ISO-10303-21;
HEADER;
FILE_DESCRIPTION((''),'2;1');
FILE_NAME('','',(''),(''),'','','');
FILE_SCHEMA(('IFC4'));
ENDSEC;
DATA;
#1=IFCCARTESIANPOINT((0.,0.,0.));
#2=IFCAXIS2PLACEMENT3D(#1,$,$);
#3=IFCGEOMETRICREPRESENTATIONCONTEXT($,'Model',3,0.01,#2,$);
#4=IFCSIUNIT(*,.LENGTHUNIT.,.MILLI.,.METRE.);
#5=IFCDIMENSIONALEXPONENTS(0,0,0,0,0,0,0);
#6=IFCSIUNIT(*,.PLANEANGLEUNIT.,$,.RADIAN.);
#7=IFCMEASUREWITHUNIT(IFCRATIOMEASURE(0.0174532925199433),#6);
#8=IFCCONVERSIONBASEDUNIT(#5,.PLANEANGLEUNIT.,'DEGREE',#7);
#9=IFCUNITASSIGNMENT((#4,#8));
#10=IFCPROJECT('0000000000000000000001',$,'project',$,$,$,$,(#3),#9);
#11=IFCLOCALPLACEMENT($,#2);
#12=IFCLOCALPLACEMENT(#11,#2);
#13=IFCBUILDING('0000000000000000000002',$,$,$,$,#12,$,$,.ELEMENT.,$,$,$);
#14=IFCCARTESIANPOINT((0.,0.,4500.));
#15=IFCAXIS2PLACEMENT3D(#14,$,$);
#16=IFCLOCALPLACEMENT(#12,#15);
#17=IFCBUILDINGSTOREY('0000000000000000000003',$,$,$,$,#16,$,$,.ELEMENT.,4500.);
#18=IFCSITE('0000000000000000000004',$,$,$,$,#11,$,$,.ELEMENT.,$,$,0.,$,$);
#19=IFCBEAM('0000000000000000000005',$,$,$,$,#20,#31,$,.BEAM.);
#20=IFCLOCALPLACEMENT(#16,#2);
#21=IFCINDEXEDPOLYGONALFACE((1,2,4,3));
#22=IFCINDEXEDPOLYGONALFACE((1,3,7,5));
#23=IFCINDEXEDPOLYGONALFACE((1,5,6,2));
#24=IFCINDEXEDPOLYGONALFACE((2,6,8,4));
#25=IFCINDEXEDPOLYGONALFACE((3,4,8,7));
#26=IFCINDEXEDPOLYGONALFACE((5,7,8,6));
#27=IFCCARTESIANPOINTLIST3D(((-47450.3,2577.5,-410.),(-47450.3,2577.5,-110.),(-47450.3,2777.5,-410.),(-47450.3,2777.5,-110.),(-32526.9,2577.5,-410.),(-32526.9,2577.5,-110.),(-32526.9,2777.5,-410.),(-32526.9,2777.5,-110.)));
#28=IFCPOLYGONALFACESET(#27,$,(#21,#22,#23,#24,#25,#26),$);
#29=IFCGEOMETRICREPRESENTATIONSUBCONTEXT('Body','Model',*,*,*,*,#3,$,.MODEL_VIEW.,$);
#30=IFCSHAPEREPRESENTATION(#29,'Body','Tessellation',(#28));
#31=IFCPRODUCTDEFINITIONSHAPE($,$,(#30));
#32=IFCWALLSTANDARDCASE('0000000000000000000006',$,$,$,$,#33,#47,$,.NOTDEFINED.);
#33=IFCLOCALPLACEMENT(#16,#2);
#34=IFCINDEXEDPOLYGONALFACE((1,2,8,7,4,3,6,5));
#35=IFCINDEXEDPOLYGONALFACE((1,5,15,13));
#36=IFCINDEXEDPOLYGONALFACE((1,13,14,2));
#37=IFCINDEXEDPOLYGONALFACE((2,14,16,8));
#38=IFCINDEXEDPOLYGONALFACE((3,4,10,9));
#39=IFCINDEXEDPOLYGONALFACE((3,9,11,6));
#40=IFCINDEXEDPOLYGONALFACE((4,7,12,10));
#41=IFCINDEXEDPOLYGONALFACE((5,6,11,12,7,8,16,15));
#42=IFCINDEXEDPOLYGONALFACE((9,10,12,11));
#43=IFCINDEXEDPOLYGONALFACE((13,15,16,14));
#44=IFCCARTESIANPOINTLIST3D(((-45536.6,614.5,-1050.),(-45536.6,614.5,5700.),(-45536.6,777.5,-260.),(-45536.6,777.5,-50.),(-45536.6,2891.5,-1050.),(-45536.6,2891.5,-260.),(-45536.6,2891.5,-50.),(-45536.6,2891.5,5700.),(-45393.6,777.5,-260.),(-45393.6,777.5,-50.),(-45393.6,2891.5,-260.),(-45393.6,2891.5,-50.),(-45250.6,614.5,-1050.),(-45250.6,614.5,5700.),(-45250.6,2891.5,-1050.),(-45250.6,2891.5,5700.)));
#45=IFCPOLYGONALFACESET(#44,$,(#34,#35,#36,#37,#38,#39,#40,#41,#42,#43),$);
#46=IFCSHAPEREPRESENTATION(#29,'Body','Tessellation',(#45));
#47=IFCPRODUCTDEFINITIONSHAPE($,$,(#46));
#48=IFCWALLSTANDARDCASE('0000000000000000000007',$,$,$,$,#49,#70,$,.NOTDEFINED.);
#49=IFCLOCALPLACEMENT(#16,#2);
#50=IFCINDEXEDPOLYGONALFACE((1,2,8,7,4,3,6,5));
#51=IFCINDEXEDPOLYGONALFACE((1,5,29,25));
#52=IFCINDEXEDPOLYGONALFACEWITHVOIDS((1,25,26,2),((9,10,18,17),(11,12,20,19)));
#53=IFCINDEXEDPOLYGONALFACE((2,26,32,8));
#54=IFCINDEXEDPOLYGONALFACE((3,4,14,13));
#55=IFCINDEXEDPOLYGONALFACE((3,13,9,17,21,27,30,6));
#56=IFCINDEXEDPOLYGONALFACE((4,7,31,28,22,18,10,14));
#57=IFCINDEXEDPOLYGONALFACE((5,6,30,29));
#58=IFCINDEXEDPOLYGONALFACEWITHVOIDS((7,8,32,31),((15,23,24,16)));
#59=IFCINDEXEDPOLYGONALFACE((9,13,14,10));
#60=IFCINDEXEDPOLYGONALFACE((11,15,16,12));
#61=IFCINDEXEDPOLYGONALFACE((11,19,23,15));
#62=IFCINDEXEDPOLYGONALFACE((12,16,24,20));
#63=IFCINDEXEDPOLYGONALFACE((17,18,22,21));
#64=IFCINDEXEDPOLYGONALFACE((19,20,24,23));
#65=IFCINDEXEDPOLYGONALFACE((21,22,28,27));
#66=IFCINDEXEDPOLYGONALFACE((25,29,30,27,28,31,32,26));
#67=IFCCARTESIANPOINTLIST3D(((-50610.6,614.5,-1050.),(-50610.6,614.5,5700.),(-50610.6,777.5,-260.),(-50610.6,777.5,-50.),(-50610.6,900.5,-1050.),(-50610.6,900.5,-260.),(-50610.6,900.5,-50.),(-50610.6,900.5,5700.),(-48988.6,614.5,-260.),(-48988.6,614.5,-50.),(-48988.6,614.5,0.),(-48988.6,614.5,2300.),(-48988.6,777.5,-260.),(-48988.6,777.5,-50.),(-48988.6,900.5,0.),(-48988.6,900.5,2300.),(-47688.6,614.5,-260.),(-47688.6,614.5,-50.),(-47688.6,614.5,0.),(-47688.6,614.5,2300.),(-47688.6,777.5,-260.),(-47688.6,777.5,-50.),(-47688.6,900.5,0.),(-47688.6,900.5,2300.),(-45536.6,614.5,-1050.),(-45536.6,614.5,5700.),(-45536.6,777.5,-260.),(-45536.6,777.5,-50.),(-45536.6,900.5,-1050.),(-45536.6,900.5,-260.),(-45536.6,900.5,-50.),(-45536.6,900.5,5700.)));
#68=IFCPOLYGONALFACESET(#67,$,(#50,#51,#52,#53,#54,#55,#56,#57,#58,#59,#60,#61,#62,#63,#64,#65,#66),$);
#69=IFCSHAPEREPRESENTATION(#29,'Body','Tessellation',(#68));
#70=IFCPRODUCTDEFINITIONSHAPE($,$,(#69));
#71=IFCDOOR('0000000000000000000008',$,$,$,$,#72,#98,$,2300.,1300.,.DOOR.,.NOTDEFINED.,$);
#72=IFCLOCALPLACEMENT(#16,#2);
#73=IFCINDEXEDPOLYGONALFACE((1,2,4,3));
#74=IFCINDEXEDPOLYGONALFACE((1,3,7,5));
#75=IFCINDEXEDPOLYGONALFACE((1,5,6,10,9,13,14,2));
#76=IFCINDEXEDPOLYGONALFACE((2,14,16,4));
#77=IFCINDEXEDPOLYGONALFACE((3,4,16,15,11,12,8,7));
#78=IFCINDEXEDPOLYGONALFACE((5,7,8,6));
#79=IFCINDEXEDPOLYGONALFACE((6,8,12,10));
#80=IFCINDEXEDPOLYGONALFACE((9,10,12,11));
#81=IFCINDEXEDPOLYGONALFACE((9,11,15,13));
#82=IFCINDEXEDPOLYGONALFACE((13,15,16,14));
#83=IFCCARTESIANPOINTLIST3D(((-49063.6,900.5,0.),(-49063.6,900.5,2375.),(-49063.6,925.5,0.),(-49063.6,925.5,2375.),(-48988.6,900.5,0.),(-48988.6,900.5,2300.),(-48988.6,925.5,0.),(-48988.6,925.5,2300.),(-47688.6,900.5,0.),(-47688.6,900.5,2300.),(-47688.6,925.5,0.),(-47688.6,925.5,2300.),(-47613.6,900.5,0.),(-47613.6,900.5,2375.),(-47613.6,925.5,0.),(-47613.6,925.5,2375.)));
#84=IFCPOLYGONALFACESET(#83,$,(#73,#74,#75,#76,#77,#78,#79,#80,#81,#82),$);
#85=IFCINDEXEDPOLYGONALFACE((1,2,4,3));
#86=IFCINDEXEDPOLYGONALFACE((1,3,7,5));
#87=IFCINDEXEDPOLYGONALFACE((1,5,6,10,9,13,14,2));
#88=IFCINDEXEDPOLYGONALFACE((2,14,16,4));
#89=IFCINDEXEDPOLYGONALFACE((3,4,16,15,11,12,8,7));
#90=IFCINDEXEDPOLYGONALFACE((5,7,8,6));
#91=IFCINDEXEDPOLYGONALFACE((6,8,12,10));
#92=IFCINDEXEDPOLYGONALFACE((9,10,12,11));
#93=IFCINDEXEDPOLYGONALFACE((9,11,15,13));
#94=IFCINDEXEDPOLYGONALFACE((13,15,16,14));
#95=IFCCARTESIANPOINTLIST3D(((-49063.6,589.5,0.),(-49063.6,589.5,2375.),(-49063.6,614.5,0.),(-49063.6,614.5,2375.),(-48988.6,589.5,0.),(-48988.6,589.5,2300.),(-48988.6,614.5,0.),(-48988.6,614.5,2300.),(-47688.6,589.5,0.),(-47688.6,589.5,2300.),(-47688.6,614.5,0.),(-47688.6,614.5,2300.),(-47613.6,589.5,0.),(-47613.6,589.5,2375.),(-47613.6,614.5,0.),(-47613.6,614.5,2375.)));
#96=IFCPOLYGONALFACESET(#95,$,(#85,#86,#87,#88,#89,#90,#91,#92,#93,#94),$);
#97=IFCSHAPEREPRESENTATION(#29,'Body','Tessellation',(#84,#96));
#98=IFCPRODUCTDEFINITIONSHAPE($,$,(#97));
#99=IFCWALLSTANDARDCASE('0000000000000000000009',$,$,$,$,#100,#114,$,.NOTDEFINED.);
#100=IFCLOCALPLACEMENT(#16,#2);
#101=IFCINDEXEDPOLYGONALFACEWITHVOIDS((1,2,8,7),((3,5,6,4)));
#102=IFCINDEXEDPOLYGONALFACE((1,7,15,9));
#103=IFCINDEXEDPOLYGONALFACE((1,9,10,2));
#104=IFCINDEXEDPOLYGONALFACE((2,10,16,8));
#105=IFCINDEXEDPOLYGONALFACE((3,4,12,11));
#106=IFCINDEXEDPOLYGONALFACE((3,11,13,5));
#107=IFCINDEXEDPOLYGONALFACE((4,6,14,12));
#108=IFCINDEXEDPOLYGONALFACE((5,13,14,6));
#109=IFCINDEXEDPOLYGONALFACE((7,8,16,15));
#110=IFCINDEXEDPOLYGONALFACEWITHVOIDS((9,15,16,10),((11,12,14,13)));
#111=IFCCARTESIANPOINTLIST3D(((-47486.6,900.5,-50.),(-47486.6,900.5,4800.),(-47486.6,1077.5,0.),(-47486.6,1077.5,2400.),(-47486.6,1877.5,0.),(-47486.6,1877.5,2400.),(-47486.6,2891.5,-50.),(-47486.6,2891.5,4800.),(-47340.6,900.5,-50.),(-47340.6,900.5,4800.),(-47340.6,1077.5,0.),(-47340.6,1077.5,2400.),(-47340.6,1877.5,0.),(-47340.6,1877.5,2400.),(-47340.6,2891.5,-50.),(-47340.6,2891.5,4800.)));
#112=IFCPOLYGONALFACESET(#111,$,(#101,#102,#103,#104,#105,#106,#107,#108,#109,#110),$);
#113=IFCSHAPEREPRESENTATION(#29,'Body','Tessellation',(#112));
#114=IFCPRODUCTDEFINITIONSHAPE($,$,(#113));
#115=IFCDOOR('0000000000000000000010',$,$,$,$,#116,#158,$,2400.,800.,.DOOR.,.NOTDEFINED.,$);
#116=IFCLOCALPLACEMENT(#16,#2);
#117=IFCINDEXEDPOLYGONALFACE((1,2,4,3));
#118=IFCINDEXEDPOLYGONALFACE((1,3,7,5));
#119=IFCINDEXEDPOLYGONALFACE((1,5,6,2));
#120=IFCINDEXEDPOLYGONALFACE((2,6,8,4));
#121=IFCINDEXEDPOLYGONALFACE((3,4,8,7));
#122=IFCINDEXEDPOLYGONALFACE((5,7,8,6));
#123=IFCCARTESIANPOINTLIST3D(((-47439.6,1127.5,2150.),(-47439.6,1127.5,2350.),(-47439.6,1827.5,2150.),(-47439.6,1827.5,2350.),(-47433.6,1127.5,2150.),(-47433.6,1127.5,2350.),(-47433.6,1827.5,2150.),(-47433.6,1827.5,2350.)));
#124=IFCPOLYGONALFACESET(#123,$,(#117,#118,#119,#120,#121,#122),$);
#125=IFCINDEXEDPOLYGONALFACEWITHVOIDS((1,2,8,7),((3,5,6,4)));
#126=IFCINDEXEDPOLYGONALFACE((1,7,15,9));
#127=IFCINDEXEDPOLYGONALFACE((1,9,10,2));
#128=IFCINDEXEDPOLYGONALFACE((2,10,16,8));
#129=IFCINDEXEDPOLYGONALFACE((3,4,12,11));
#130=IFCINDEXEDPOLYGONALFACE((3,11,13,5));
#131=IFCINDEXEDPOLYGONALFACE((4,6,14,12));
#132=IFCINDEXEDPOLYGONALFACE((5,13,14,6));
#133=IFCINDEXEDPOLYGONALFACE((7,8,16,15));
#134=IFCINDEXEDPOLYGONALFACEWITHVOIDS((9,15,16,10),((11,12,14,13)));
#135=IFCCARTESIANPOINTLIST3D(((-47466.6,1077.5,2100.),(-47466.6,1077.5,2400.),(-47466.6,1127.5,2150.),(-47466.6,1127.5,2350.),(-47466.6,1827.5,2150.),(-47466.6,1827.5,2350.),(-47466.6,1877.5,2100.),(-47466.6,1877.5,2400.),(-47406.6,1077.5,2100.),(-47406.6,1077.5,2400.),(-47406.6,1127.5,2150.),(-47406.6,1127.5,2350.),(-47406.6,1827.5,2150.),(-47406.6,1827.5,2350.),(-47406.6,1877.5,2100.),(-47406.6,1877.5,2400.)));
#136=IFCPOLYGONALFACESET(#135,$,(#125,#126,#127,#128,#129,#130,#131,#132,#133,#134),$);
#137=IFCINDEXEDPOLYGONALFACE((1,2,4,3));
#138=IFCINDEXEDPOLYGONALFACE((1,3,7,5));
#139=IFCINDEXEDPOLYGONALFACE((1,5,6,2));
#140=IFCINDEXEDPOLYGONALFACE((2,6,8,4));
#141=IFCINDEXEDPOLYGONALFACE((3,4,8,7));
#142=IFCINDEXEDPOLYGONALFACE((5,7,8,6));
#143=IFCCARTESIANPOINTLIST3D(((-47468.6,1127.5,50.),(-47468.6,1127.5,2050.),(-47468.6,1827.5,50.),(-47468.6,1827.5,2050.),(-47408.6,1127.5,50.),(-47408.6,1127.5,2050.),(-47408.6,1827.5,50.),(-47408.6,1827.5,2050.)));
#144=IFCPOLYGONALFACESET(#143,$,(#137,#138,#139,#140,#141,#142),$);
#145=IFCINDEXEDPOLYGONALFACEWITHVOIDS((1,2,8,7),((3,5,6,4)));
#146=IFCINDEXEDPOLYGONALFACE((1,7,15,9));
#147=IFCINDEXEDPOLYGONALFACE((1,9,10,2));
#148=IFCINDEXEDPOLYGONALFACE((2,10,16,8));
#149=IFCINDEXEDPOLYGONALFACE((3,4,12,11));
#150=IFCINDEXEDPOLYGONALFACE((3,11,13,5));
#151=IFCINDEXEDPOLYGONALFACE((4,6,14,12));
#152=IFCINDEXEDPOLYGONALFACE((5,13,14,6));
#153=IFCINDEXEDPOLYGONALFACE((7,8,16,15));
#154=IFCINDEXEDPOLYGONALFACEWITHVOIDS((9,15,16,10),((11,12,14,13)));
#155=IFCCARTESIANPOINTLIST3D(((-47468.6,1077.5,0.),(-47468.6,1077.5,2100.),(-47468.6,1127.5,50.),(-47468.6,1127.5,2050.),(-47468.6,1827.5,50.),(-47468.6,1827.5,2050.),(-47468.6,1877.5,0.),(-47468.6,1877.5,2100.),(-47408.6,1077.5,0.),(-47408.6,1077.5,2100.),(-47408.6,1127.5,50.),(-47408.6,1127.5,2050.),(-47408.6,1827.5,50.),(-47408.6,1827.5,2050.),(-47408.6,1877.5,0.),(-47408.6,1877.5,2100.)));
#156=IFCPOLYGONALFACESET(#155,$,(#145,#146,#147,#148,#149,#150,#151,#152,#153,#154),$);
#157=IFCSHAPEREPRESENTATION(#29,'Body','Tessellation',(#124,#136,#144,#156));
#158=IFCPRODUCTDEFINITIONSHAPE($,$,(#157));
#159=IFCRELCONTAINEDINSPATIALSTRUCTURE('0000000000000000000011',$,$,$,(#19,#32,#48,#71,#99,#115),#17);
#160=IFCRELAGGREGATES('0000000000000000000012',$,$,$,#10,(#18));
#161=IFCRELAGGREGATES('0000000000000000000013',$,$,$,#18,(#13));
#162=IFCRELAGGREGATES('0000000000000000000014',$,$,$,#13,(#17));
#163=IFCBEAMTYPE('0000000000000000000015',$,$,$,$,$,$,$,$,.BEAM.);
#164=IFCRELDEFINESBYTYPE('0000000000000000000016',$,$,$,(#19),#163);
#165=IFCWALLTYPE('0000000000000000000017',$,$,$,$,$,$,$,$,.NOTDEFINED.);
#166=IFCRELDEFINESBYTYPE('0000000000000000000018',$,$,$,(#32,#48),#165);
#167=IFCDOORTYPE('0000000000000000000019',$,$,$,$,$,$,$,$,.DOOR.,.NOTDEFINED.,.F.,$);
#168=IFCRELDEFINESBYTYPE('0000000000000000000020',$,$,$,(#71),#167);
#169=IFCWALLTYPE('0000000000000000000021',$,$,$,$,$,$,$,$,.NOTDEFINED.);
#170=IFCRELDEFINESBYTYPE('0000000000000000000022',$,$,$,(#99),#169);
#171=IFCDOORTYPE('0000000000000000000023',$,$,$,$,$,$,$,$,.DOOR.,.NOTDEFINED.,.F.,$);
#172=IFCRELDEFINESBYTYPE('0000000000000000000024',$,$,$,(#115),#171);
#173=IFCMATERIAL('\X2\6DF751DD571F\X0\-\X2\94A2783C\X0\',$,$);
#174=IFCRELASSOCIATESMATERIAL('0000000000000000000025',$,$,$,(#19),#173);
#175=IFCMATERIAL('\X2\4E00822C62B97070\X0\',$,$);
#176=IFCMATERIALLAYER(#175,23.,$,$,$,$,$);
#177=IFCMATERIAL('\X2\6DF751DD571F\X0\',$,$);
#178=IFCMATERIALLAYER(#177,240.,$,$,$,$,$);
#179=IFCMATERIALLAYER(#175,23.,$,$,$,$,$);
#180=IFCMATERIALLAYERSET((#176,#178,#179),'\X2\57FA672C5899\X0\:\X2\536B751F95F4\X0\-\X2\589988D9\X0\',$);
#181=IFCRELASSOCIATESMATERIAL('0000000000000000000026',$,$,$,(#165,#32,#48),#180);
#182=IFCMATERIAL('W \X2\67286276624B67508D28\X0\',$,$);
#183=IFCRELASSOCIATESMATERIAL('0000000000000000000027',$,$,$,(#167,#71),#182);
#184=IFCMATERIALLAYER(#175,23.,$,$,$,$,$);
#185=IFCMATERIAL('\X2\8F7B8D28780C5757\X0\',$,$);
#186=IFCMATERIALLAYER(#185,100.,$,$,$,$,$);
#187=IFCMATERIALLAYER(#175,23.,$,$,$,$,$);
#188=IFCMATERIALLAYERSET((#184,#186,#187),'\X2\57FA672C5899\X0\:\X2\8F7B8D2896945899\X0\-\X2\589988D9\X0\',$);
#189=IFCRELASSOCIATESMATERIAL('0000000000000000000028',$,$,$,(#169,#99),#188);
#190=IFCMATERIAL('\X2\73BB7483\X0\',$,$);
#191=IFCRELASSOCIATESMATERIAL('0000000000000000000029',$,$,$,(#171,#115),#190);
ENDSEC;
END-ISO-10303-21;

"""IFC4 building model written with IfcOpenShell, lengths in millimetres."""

from ifc_helpers import new_model, entity, si_unit, converted_unit, frame, frame_2d, origin, place, context, subcontext, project, spatial, polyline, rectangle, outline, extrude, source, transform, mapped, material, layer, layer_set, layer_usage, type_object, type_shapes, element, fill, save


model = new_model("IFC4")

# Units and contexts
model_context = context("Model", 3, precision=0.01, world=origin())
body_context = subcontext(model_context, "Body", "Model", "MODEL_VIEW")
ifc_project = project(units=[si_unit("LENGTHUNIT", "METRE", prefix="MILLI"), converted_unit("PLANEANGLEUNIT", "DEGREE", entity("IfcRatioMeasure", 0.0174532925199433), si_unit("PLANEANGLEUNIT", "RADIAN"), dimensions=[0, 0, 0, 0, 0, 0, 0])], contexts=[model_context])

# Site, building, storey
site_placement = place(None, origin())
site = spatial("IfcSite", under=ifc_project, at=site_placement, CompositionType="ELEMENT", RefElevation=0.0)
building_placement = place(site_placement, origin())
building = spatial("IfcBuilding", under=site, at=building_placement, CompositionType="ELEMENT")
storey_placement = place(building_placement, frame((0.0, 0.0, 4500.0)))
storey = spatial("IfcBuildingStorey", under=building, at=storey_placement, CompositionType="ELEMENT", Elevation=4500.0)

# Beam
ifc_material_1 = material(Name="混凝土-钢砼")
beam_type = type_object("IfcBeamType", PredefinedType="BEAM")
beam_placement = place(storey_placement, frame((-47413.6, 2677.5, -110.0)))
element("IfcBeam", 1, at=beam_placement, inside=storey, type_object=beam_type, material=ifc_material_1, PredefinedType="BEAM", context=body_context, shape_type="SweptSolid", body=[
    extrude(rectangle(XDim=300.0, YDim=200.0, at=frame_2d((0.0, 0.0), x_axis=(1.0, 0.0))), frame((-36.7, 0.0, -150.0), z_axis=(1.0, 0.0, 0.0), x_axis=(0.0, 0.0, -1.0)), (0.0, 0.0, 1.0), 14923.4),
])

# Wall, opening
ifc_material_2 = material(Name="一般抹灰")
ifc_layer_1 = layer(ifc_material_2, 23.0)
ifc_material_3 = material(Name="混凝土")
ifc_layer_2 = layer(ifc_material_3, 240.0)
ifc_layer_3 = layer(ifc_material_2, 23.0)
ifc_layer_set_1 = layer_set([ifc_layer_1, ifc_layer_2, ifc_layer_3], Name="基本墙:卫生间-墙裙")
ifc_layer_usage_1 = layer_usage(ifc_layer_set_1, "AXIS2", "NEGATIVE", 143.0)
wall_type_1 = type_object("IfcWallType", PredefinedType="NOTDEFINED", material=ifc_layer_set_1)
wall_1_placement = place(storey_placement, frame((-45393.6, 2891.5, -1050.0), z_axis=(0.0, 0.0, 1.0), x_axis=(0.0, -1.0, 0.0)))
wall_1 = element("IfcWallStandardCase", 2, at=wall_1_placement, inside=storey, type_object=wall_type_1, material=ifc_layer_usage_1, PredefinedType="NOTDEFINED", context=body_context, shape_type="SweptSolid", body=[
    extrude(rectangle(XDim=2277.0, YDim=286.0, at=frame_2d((1138.5, 0.0), x_axis=(-1.0, 0.0))), origin(), (0.0, 0.0, 1.0), 6750.0),
])
opening_1_placement = place(storey_placement, frame((-45393.6, 2891.5, -1050.0), z_axis=(0.0, 0.0, 1.0), x_axis=(0.0, -1.0, 0.0)))
element("IfcOpeningElement", 3, at=opening_1_placement, cuts=wall_1, PredefinedType="OPENING", context=body_context, shape_type="SweptSolid", body=[
    extrude(rectangle(XDim=143.0, YDim=2114.0, at=frame_2d((14.3, 186.8), x_axis=(1.0, 0.0))), frame((1243.8, -85.8, 790.0), z_axis=(0.0, 0.0, 1.0), x_axis=(0.0, 1.0, 0.0)), (0.0, 0.0, 1.0), 210.0),
])

# Wall, openings, door
ifc_layer_usage_2 = layer_usage(ifc_layer_set_1, "AXIS2", "NEGATIVE", 143.0)
wall_2_placement = place(storey_placement, frame((-45536.6, 757.5, -1050.0), z_axis=(0.0, 0.0, 1.0), x_axis=(-1.0, 0.0, 0.0)))
wall_2 = element("IfcWallStandardCase", 4, at=wall_2_placement, inside=storey, type_object=wall_type_1, material=ifc_layer_usage_2, PredefinedType="NOTDEFINED", context=body_context, shape_type="SweptSolid", body=[
    extrude(rectangle(XDim=5074.0, YDim=286.0, at=frame_2d((2537.0, 0.0), x_axis=(-1.0, 0.0))), origin(), (0.0, 0.0, 1.0), 6750.0),
])
opening_2_placement = place(storey_placement, frame((-45536.6, 757.5, -1050.0), z_axis=(0.0, 0.0, 1.0), x_axis=(-1.0, 0.0, 0.0)))
element("IfcOpeningElement", 5, at=opening_2_placement, cuts=wall_2, PredefinedType="OPENING", context=body_context, shape_type="SweptSolid", body=[
    extrude(outline(polyline([(517.5, 10.0), (2669.5, 10.0), (2669.5, 133.0), (-2404.5, 133.0), (-2404.5, 10.0), (-782.5, 10.0), (-782.5, -153.0), (517.5, -153.0), (517.5, 10.0)])), frame((2669.5, -10.0, 790.0), z_axis=(0.0, 0.0, 1.0), x_axis=(-1.0, 0.0, 0.0)), (0.0, 0.0, 1.0), 210.0),
])
opening_3_placement = place(wall_2_placement, frame((3452.0, 143.0, 1050.0)))
opening_3 = element("IfcOpeningElement", 6, at=opening_3_placement, cuts=wall_2, PredefinedType="OPENING", context=body_context, shape_type="SweptSolid", body=[
    extrude(rectangle(XDim=2300.0, YDim=1300.0, at=frame_2d((1150.0, 650.0), x_axis=(1.0, 0.0))), frame((0.0, 0.0, 0.0), z_axis=(0.0, -1.0, 0.0), x_axis=(0.0, 0.0, 1.0)), (0.0, 0.0, 1.0), 286.0),
])
ifc_material_4 = material(Name="W 木扶手材质")
door_type_1 = type_object("IfcDoorType", OperationType="NOTDEFINED", ParameterTakesPrecedence=False, PredefinedType="DOOR", material=ifc_material_4)
shared_shape_1 = source(origin(), body_context, "Body", "SweptSolid", [
    extrude(outline(polyline([(-1131.2, 650.0), (1168.7, 650.0), (1168.7, 725.0), (-1206.2, 725.0), (-1206.2, -725.0), (1168.7, -725.0), (1168.7, -650.0), (-1131.2, -650.0), (-1131.2, 650.0)])), frame((650.0, 286.0, 1168.7), z_axis=(0.0, 1.0, 0.0), x_axis=(0.0, 0.0, -1.0)), (0.0, 0.0, 1.0), 25.0),
    extrude(outline(polyline([(-725.0, -1206.2), (725.0, -1206.2), (725.0, 1168.7), (650.0, 1168.7), (650.0, -1131.2), (-650.0, -1131.2), (-650.0, 1168.7), (-725.0, 1168.7), (-725.0, -1206.2)])), frame((650.0, -25.0, 1168.7), z_axis=(0.0, 1.0, 0.0), x_axis=(1.0, 0.0, 0.0)), (0.0, 0.0, 1.0), 25.0),
])
type_shapes(door_type_1, [shared_shape_1])
door_1_placement = place(opening_3_placement, frame((0.0, 0.0, 0.0), z_axis=(0.0, 0.0, 1.0), x_axis=(-1.0, 0.0, 0.0)))
door_1 = element("IfcDoor", 7, at=door_1_placement, inside=storey, type_object=door_type_1, material=ifc_material_4, OperationType="NOTDEFINED", OverallHeight=2300.0, OverallWidth=1300.0, PredefinedType="DOOR", context=body_context, shape_type="MappedRepresentation", body=[
    mapped(shared_shape_1, transform((0.0, 0.0, 0.0), scale=1.0)),
])
fill(opening_3, door_1)

# Wall, opening, door
ifc_layer_4 = layer(ifc_material_2, 23.0)
ifc_material_5 = material(Name="轻质砌块")
ifc_layer_5 = layer(ifc_material_5, 100.0)
ifc_layer_6 = layer(ifc_material_2, 23.0)
ifc_layer_set_2 = layer_set([ifc_layer_4, ifc_layer_5, ifc_layer_6], Name="基本墙:轻质隔墙-墙裙")
ifc_layer_usage_3 = layer_usage(ifc_layer_set_2, "AXIS2", "NEGATIVE", 73.0)
wall_type_2 = type_object("IfcWallType", PredefinedType="NOTDEFINED", material=ifc_layer_set_2)
wall_3_placement = place(storey_placement, frame((-47413.6, 900.5, -50.0), z_axis=(0.0, 0.0, 1.0), x_axis=(0.0, 1.0, 0.0)))
wall_3 = element("IfcWallStandardCase", 8, at=wall_3_placement, inside=storey, type_object=wall_type_2, material=ifc_layer_usage_3, PredefinedType="NOTDEFINED", context=body_context, shape_type="SweptSolid", body=[
    extrude(rectangle(XDim=1991.0, YDim=146.0, at=frame_2d((995.5, 0.0), x_axis=(-1.0, 0.0))), origin(), (0.0, 0.0, 1.0), 4850.0),
])
opening_4_placement = place(wall_3_placement, frame((977.0, 73.0, 50.0)))
opening_4 = element("IfcOpeningElement", 9, at=opening_4_placement, cuts=wall_3, PredefinedType="OPENING", context=body_context, shape_type="SweptSolid", body=[
    extrude(rectangle(XDim=2400.0, YDim=800.0, at=frame_2d((1200.0, 400.0), x_axis=(1.0, 0.0))), frame((0.0, 0.0, 0.0), z_axis=(0.0, -1.0, 0.0), x_axis=(0.0, 0.0, 1.0)), (0.0, 0.0, 1.0), 146.0),
])
ifc_material_6 = material(Name="玻璃")
door_type_2 = type_object("IfcDoorType", OperationType="NOTDEFINED", ParameterTakesPrecedence=False, PredefinedType="DOOR", material=ifc_material_6)
shared_shape_2 = source(origin(), body_context, "Body", "SweptSolid", [
    extrude(rectangle(XDim=700.0, YDim=6.0, at=frame_2d((0.0, 0.0), x_axis=(1.0, 0.0))), frame((400.0, 50.0, 2150.0), z_axis=(0.0, 0.0, 1.0), x_axis=(-1.0, 0.0, 0.0)), (0.0, 0.0, 1.0), 200.0),
    extrude(outline(polyline([(-400.0, -150.0), (400.0, -150.0), (400.0, 150.0), (-400.0, 150.0), (-400.0, -150.0)]), holes=[polyline([(-350.0, -100.0), (-350.0, 100.0), (350.0, 100.0), (350.0, -100.0), (-350.0, -100.0)])]), frame((400.0, 80.0, 2250.0), z_axis=(0.0, -1.0, 0.0), x_axis=(-1.0, 0.0, 0.0)), (0.0, 0.0, 1.0), 60.0),
    extrude(rectangle(XDim=60.0, YDim=700.0, at=frame_2d((0.0, 0.0), x_axis=(1.0, 0.0))), frame((400.0, 48.0, 50.0), z_axis=(0.0, 0.0, 1.0), x_axis=(0.0, -1.0, 0.0)), (0.0, 0.0, 1.0), 2000.0),
    extrude(outline(polyline([(-1050.0, -400.0), (1050.0, -400.0), (1050.0, 400.0), (-1050.0, 400.0), (-1050.0, -400.0)]), holes=[polyline([(-1000.0, 350.0), (1000.0, 350.0), (1000.0, -350.0), (-1000.0, -350.0), (-1000.0, 350.0)])]), frame((400.0, 78.0, 1050.0), z_axis=(0.0, -1.0, 0.0), x_axis=(0.0, 0.0, -1.0)), (0.0, 0.0, 1.0), 60.0),
])
type_shapes(door_type_2, [shared_shape_2])
door_2_placement = place(opening_4_placement, frame((0.0, 0.0, 0.0), z_axis=(0.0, 0.0, 1.0), x_axis=(-1.0, 0.0, 0.0)))
door_2 = element("IfcDoor", 10, at=door_2_placement, inside=storey, type_object=door_type_2, material=ifc_material_6, OperationType="NOTDEFINED", OverallHeight=2400.0, OverallWidth=800.0, PredefinedType="DOOR", context=body_context, shape_type="MappedRepresentation", body=[
    mapped(shared_shape_2, transform((0.0, 0.0, 0.0), scale=1.0)),
])
fill(opening_4, door_2)

save(model, "model.ifc")
